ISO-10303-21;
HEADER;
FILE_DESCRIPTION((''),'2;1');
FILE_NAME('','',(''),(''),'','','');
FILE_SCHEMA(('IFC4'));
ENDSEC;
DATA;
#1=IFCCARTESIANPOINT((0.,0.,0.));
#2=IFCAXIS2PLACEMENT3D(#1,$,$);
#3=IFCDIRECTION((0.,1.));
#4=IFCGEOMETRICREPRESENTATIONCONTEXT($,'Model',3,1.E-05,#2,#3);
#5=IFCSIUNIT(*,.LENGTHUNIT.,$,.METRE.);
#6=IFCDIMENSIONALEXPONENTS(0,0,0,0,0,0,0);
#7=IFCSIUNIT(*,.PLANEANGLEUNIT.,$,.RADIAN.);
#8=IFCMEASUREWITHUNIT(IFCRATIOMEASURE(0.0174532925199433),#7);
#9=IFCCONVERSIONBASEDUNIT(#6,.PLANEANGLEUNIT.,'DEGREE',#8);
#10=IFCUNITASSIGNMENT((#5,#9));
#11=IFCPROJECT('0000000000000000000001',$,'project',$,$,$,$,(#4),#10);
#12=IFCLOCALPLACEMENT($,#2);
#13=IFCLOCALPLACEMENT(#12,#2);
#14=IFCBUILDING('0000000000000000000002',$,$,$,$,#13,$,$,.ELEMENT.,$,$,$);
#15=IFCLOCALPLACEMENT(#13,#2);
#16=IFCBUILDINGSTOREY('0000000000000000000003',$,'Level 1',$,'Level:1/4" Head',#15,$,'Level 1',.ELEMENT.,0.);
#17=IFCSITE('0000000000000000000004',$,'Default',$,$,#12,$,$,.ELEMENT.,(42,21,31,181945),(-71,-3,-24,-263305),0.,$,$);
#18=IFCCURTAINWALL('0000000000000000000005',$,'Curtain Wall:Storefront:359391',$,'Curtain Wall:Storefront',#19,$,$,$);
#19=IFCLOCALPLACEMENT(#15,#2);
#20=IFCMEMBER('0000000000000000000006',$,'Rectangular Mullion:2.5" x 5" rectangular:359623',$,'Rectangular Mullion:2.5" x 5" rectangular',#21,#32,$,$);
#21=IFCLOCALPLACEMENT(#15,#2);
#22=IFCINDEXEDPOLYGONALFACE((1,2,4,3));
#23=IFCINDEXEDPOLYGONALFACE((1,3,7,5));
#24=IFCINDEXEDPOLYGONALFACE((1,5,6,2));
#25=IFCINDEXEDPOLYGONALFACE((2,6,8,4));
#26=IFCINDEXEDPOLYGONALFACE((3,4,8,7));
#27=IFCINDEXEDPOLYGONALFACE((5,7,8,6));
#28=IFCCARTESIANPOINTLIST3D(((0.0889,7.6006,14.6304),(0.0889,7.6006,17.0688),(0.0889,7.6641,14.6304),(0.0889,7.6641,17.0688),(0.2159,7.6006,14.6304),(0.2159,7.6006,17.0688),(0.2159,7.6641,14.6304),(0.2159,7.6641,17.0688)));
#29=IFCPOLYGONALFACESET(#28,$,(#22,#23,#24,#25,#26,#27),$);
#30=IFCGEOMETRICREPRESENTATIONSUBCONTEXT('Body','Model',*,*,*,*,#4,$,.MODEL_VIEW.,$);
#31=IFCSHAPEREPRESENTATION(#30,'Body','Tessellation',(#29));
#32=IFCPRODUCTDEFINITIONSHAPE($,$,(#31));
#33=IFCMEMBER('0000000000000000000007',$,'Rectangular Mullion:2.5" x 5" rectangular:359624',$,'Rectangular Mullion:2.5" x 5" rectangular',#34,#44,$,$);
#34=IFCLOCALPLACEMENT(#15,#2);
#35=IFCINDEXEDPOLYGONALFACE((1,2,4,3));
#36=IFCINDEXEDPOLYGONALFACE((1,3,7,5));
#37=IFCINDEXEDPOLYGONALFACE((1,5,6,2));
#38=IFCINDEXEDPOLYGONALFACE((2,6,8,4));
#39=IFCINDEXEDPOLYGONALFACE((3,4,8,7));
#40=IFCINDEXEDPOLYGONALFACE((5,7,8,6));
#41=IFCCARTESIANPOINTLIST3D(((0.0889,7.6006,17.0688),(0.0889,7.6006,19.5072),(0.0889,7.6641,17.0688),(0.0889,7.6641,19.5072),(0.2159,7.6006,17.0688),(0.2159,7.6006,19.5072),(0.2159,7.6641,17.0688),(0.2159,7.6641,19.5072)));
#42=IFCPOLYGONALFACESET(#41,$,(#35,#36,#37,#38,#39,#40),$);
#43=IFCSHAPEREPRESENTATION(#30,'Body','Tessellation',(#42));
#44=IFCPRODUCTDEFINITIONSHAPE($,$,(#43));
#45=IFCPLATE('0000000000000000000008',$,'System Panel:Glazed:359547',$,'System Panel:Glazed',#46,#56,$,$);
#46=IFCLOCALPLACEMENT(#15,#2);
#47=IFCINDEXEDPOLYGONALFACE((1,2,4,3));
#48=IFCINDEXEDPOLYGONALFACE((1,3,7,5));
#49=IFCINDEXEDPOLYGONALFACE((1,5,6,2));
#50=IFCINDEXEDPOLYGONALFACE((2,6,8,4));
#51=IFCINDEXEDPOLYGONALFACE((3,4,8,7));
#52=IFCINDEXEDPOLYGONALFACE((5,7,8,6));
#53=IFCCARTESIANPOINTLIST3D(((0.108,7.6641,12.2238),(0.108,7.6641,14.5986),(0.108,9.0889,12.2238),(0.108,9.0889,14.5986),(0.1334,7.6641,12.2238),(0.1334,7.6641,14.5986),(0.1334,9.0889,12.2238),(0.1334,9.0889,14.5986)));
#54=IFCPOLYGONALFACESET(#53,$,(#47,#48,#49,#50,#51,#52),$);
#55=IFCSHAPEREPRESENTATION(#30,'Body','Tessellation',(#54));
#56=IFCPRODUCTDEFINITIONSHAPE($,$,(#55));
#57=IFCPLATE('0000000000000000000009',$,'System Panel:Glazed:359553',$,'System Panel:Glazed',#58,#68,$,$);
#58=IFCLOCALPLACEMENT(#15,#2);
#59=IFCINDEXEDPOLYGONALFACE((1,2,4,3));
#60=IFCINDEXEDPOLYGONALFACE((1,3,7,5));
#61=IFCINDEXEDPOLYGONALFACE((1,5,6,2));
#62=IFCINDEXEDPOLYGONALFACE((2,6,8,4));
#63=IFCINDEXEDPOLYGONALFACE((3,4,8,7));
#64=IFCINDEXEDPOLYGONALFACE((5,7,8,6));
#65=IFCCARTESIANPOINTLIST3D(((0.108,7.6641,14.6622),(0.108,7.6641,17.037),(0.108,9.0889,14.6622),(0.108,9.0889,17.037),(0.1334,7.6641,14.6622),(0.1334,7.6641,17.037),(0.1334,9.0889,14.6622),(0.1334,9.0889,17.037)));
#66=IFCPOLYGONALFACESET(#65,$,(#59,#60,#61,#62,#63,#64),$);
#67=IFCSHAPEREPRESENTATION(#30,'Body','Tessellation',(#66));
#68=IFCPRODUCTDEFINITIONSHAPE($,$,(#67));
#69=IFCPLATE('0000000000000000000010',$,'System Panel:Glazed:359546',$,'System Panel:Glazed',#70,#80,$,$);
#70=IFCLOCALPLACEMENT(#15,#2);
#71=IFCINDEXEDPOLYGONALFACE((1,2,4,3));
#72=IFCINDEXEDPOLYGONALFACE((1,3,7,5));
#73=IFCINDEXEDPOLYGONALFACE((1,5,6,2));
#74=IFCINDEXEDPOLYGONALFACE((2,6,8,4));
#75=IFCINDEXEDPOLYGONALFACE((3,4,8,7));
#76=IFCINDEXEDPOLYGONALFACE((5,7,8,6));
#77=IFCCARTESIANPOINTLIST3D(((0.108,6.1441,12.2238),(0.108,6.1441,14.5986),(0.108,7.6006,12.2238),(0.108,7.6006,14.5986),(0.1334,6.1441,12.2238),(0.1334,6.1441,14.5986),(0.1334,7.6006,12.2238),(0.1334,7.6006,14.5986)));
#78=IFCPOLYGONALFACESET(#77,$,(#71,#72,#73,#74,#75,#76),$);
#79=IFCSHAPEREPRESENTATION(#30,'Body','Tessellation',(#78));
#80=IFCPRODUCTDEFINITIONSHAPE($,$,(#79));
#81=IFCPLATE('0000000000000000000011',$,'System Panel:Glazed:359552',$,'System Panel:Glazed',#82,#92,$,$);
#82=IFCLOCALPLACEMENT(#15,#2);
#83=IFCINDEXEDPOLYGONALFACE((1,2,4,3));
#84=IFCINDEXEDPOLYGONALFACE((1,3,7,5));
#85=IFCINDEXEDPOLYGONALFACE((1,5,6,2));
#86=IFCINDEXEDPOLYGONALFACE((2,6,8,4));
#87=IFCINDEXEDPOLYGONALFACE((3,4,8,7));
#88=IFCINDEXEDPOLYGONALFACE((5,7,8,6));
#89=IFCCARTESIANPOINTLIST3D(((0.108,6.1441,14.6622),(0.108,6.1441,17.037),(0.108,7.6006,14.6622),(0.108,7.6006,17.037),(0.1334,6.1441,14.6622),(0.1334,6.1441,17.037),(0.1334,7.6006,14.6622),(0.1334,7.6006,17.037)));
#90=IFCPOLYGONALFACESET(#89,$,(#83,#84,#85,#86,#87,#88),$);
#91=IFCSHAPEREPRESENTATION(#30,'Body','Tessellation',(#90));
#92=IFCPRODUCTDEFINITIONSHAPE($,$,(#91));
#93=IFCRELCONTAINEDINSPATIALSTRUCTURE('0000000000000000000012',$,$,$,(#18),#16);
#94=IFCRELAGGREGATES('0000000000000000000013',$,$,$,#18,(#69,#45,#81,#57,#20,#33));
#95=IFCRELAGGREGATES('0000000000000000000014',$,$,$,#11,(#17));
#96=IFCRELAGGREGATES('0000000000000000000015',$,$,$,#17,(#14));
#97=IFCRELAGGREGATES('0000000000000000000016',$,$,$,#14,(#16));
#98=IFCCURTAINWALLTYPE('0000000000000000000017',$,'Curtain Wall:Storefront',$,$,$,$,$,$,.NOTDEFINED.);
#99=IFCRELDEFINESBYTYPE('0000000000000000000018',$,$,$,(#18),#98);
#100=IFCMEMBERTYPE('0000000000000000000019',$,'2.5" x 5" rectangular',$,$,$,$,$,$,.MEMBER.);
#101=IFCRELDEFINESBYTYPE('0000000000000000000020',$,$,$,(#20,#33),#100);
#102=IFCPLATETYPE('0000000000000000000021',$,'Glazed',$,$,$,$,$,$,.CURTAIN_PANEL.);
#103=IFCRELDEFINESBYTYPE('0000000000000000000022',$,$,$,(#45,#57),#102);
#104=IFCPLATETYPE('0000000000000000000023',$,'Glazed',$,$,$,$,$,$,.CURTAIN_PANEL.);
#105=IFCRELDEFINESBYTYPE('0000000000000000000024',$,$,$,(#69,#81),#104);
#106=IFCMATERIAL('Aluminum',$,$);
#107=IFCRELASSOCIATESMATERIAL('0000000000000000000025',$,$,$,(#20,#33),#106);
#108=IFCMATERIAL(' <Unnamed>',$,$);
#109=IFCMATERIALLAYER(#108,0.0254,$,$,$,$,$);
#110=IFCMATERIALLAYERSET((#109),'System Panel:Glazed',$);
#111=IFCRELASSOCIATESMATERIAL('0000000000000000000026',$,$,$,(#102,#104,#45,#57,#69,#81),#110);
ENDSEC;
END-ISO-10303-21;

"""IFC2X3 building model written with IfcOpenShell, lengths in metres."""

from ifc_helpers import new_model, entity, si_unit, converted_unit, direction, frame, frame_2d, origin, origin_2d_with_axis, place, context, subcontext, project, spatial, rectangle, extrude, source, transform, mapped, material, layer, layer_set, layer_usage, type_object, type_shapes, element, aggregate, save


model = new_model("IFC2X3")

# Units and contexts
model_context = context("Model", 3, precision=1e-05, world=origin(), true_north=direction((0.0, 1.0)))
body_context = subcontext(model_context, "Body", "Model", "MODEL_VIEW")
ifc_project = project(units=[si_unit("LENGTHUNIT", "METRE"), converted_unit("PLANEANGLEUNIT", "DEGREE", entity("IfcRatioMeasure", 0.0174532925199433), si_unit("PLANEANGLEUNIT", "RADIAN"), dimensions=[0, 0, 0, 0, 0, 0, 0])], contexts=[model_context])

# Site, building, storey
site_placement = place(None, origin())
site = spatial("IfcSite", under=ifc_project, at=site_placement, Name="Default", CompositionType="ELEMENT", RefLatitude=(42, 21, 31, 181945), RefLongitude=(-71, -3, -24, -263305), RefElevation=0.0)
building_placement = place(site_placement, origin())
building = spatial("IfcBuilding", under=site, at=building_placement, CompositionType="ELEMENT")
storey_placement = place(building_placement, origin())
storey = spatial("IfcBuildingStorey", under=building, at=storey_placement, Name="Level 1", ObjectType="Level:1/4\" Head", LongName="Level 1", CompositionType="ELEMENT", Elevation=0.0)

# Curtain wall, members, plates
curtain_wall_type = type_object("IfcCurtainWallType", Name="Curtain Wall:Storefront", PredefinedType="NOTDEFINED")
curtain_wall_placement = place(storey_placement, origin())
curtain_wall = element("IfcCurtainWall", 1, at=curtain_wall_placement, inside=storey, type_object=curtain_wall_type, Name="Curtain Wall:Storefront:359391", ObjectType="Curtain Wall:Storefront")
ifc_material_1 = material(Name="Aluminum")
member_type_1 = type_object("IfcMemberType", Name="2.5\" x 5\" rectangular", PredefinedType="MEMBER")
shared_shape_1 = source(origin(), body_context, "Body", "SweptSolid", [
    extrude(rectangle(XDim=0.127, YDim=0.0635, at=origin_2d_with_axis()), frame((0.0, 0.0, -2.4384), z_axis=(0.0, 0.0, 1.0), x_axis=(0.0, -1.0, 0.0)), (0.0, 0.0, 1.0), 2.4384),
])
type_shapes(member_type_1, [shared_shape_1])
member_1_placement = place(storey_placement, frame((0.1524, 7.6324, 14.6304), z_axis=(0.0, 0.0, -1.0), x_axis=(0.0, 1.0, 0.0)))
member_1 = element("IfcMember", 2, at=member_1_placement, type_object=member_type_1, material=ifc_material_1, Name="Rectangular Mullion:2.5\" x 5\" rectangular:359623", ObjectType="Rectangular Mullion:2.5\" x 5\" rectangular", context=body_context, shape_type="MappedRepresentation", body=[
    mapped(shared_shape_1, transform((0.0, 0.0, 0.0), scale=1.0)),
])
member_2_placement = place(storey_placement, frame((0.1524, 7.6324, 17.0688), z_axis=(0.0, 0.0, -1.0), x_axis=(0.0, 1.0, 0.0)))
member_2 = element("IfcMember", 3, at=member_2_placement, type_object=member_type_1, material=ifc_material_1, Name="Rectangular Mullion:2.5\" x 5\" rectangular:359624", ObjectType="Rectangular Mullion:2.5\" x 5\" rectangular", context=body_context, shape_type="MappedRepresentation", body=[
    mapped(shared_shape_1, transform((0.0, 0.0, 0.0), scale=1.0)),
])
ifc_material_2 = material(Name=" <Unnamed>")
ifc_layer = layer(ifc_material_2, 0.0254)
ifc_layer_set = layer_set([ifc_layer], Name="System Panel:Glazed")
ifc_layer_usage_1 = layer_usage(ifc_layer_set, "AXIS3", "POSITIVE", 0.1042)
plate_type_1 = type_object("IfcPlateType", Name="Glazed", PredefinedType="CURTAIN_PANEL", material=ifc_layer_set)
shared_shape_2 = source(origin(), body_context, "Body", "SweptSolid", [
    extrude(rectangle(XDim=0.0254, YDim=1.4248, at=frame_2d((0.0, 0.0), x_axis=(1.0, 0.0))), frame((0.7124, 0.0127, 0.0), z_axis=(0.0, 0.0, 1.0), x_axis=(0.0, 1.0, 0.0)), (0.0, 0.0, 1.0), 2.3749),
])
type_shapes(plate_type_1, [shared_shape_2])
plate_1_placement = place(curtain_wall_placement, frame((0.1334, 7.6641, 12.2238), z_axis=(0.0, 0.0, 1.0), x_axis=(0.0, 1.0, 0.0)))
plate_1 = element("IfcPlate", 4, at=plate_1_placement, type_object=plate_type_1, material=ifc_layer_usage_1, Name="System Panel:Glazed:359547", ObjectType="System Panel:Glazed", context=body_context, shape_type="MappedRepresentation", body=[
    mapped(shared_shape_2, transform((0.0, 0.0, 0.0), scale=1.0)),
])
ifc_layer_usage_2 = layer_usage(ifc_layer_set, "AXIS3", "POSITIVE", 0.1042)
plate_2_placement = place(curtain_wall_placement, frame((0.1334, 7.6641, 14.6622), z_axis=(0.0, 0.0, 1.0), x_axis=(0.0, 1.0, 0.0)))
plate_2 = element("IfcPlate", 5, at=plate_2_placement, type_object=plate_type_1, material=ifc_layer_usage_2, Name="System Panel:Glazed:359553", ObjectType="System Panel:Glazed", context=body_context, shape_type="MappedRepresentation", body=[
    mapped(shared_shape_2, transform((0.0, 0.0, 0.0), scale=1.0)),
])
ifc_layer_usage_3 = layer_usage(ifc_layer_set, "AXIS3", "POSITIVE", 0.1042)
plate_type_2 = type_object("IfcPlateType", Name="Glazed", PredefinedType="CURTAIN_PANEL", material=ifc_layer_set)
shared_shape_3 = source(origin(), body_context, "Body", "SweptSolid", [
    extrude(rectangle(XDim=0.0254, YDim=1.4565, at=frame_2d((0.0, 0.0), x_axis=(1.0, 0.0))), frame((0.7282, 0.0127, 0.0), z_axis=(0.0, 0.0, 1.0), x_axis=(0.0, 1.0, 0.0)), (0.0, 0.0, 1.0), 2.3749),
])
type_shapes(plate_type_2, [shared_shape_3])
plate_3_placement = place(curtain_wall_placement, frame((0.1334, 6.1441, 12.2238), z_axis=(0.0, 0.0, 1.0), x_axis=(0.0, 1.0, 0.0)))
plate_3 = element("IfcPlate", 6, at=plate_3_placement, type_object=plate_type_2, material=ifc_layer_usage_3, Name="System Panel:Glazed:359546", ObjectType="System Panel:Glazed", context=body_context, shape_type="MappedRepresentation", body=[
    mapped(shared_shape_3, transform((0.0, 0.0, 0.0), scale=1.0)),
])
ifc_layer_usage_4 = layer_usage(ifc_layer_set, "AXIS3", "POSITIVE", 0.1042)
plate_4_placement = place(curtain_wall_placement, frame((0.1334, 6.1441, 14.6622), z_axis=(0.0, 0.0, 1.0), x_axis=(0.0, 1.0, 0.0)))
plate_4 = element("IfcPlate", 7, at=plate_4_placement, type_object=plate_type_2, material=ifc_layer_usage_4, Name="System Panel:Glazed:359552", ObjectType="System Panel:Glazed", context=body_context, shape_type="MappedRepresentation", body=[
    mapped(shared_shape_3, transform((0.0, 0.0, 0.0), scale=1.0)),
])
aggregate(curtain_wall, [plate_3, plate_1, plate_4, plate_2, member_1, member_2])

save(model, "model.ifc")
